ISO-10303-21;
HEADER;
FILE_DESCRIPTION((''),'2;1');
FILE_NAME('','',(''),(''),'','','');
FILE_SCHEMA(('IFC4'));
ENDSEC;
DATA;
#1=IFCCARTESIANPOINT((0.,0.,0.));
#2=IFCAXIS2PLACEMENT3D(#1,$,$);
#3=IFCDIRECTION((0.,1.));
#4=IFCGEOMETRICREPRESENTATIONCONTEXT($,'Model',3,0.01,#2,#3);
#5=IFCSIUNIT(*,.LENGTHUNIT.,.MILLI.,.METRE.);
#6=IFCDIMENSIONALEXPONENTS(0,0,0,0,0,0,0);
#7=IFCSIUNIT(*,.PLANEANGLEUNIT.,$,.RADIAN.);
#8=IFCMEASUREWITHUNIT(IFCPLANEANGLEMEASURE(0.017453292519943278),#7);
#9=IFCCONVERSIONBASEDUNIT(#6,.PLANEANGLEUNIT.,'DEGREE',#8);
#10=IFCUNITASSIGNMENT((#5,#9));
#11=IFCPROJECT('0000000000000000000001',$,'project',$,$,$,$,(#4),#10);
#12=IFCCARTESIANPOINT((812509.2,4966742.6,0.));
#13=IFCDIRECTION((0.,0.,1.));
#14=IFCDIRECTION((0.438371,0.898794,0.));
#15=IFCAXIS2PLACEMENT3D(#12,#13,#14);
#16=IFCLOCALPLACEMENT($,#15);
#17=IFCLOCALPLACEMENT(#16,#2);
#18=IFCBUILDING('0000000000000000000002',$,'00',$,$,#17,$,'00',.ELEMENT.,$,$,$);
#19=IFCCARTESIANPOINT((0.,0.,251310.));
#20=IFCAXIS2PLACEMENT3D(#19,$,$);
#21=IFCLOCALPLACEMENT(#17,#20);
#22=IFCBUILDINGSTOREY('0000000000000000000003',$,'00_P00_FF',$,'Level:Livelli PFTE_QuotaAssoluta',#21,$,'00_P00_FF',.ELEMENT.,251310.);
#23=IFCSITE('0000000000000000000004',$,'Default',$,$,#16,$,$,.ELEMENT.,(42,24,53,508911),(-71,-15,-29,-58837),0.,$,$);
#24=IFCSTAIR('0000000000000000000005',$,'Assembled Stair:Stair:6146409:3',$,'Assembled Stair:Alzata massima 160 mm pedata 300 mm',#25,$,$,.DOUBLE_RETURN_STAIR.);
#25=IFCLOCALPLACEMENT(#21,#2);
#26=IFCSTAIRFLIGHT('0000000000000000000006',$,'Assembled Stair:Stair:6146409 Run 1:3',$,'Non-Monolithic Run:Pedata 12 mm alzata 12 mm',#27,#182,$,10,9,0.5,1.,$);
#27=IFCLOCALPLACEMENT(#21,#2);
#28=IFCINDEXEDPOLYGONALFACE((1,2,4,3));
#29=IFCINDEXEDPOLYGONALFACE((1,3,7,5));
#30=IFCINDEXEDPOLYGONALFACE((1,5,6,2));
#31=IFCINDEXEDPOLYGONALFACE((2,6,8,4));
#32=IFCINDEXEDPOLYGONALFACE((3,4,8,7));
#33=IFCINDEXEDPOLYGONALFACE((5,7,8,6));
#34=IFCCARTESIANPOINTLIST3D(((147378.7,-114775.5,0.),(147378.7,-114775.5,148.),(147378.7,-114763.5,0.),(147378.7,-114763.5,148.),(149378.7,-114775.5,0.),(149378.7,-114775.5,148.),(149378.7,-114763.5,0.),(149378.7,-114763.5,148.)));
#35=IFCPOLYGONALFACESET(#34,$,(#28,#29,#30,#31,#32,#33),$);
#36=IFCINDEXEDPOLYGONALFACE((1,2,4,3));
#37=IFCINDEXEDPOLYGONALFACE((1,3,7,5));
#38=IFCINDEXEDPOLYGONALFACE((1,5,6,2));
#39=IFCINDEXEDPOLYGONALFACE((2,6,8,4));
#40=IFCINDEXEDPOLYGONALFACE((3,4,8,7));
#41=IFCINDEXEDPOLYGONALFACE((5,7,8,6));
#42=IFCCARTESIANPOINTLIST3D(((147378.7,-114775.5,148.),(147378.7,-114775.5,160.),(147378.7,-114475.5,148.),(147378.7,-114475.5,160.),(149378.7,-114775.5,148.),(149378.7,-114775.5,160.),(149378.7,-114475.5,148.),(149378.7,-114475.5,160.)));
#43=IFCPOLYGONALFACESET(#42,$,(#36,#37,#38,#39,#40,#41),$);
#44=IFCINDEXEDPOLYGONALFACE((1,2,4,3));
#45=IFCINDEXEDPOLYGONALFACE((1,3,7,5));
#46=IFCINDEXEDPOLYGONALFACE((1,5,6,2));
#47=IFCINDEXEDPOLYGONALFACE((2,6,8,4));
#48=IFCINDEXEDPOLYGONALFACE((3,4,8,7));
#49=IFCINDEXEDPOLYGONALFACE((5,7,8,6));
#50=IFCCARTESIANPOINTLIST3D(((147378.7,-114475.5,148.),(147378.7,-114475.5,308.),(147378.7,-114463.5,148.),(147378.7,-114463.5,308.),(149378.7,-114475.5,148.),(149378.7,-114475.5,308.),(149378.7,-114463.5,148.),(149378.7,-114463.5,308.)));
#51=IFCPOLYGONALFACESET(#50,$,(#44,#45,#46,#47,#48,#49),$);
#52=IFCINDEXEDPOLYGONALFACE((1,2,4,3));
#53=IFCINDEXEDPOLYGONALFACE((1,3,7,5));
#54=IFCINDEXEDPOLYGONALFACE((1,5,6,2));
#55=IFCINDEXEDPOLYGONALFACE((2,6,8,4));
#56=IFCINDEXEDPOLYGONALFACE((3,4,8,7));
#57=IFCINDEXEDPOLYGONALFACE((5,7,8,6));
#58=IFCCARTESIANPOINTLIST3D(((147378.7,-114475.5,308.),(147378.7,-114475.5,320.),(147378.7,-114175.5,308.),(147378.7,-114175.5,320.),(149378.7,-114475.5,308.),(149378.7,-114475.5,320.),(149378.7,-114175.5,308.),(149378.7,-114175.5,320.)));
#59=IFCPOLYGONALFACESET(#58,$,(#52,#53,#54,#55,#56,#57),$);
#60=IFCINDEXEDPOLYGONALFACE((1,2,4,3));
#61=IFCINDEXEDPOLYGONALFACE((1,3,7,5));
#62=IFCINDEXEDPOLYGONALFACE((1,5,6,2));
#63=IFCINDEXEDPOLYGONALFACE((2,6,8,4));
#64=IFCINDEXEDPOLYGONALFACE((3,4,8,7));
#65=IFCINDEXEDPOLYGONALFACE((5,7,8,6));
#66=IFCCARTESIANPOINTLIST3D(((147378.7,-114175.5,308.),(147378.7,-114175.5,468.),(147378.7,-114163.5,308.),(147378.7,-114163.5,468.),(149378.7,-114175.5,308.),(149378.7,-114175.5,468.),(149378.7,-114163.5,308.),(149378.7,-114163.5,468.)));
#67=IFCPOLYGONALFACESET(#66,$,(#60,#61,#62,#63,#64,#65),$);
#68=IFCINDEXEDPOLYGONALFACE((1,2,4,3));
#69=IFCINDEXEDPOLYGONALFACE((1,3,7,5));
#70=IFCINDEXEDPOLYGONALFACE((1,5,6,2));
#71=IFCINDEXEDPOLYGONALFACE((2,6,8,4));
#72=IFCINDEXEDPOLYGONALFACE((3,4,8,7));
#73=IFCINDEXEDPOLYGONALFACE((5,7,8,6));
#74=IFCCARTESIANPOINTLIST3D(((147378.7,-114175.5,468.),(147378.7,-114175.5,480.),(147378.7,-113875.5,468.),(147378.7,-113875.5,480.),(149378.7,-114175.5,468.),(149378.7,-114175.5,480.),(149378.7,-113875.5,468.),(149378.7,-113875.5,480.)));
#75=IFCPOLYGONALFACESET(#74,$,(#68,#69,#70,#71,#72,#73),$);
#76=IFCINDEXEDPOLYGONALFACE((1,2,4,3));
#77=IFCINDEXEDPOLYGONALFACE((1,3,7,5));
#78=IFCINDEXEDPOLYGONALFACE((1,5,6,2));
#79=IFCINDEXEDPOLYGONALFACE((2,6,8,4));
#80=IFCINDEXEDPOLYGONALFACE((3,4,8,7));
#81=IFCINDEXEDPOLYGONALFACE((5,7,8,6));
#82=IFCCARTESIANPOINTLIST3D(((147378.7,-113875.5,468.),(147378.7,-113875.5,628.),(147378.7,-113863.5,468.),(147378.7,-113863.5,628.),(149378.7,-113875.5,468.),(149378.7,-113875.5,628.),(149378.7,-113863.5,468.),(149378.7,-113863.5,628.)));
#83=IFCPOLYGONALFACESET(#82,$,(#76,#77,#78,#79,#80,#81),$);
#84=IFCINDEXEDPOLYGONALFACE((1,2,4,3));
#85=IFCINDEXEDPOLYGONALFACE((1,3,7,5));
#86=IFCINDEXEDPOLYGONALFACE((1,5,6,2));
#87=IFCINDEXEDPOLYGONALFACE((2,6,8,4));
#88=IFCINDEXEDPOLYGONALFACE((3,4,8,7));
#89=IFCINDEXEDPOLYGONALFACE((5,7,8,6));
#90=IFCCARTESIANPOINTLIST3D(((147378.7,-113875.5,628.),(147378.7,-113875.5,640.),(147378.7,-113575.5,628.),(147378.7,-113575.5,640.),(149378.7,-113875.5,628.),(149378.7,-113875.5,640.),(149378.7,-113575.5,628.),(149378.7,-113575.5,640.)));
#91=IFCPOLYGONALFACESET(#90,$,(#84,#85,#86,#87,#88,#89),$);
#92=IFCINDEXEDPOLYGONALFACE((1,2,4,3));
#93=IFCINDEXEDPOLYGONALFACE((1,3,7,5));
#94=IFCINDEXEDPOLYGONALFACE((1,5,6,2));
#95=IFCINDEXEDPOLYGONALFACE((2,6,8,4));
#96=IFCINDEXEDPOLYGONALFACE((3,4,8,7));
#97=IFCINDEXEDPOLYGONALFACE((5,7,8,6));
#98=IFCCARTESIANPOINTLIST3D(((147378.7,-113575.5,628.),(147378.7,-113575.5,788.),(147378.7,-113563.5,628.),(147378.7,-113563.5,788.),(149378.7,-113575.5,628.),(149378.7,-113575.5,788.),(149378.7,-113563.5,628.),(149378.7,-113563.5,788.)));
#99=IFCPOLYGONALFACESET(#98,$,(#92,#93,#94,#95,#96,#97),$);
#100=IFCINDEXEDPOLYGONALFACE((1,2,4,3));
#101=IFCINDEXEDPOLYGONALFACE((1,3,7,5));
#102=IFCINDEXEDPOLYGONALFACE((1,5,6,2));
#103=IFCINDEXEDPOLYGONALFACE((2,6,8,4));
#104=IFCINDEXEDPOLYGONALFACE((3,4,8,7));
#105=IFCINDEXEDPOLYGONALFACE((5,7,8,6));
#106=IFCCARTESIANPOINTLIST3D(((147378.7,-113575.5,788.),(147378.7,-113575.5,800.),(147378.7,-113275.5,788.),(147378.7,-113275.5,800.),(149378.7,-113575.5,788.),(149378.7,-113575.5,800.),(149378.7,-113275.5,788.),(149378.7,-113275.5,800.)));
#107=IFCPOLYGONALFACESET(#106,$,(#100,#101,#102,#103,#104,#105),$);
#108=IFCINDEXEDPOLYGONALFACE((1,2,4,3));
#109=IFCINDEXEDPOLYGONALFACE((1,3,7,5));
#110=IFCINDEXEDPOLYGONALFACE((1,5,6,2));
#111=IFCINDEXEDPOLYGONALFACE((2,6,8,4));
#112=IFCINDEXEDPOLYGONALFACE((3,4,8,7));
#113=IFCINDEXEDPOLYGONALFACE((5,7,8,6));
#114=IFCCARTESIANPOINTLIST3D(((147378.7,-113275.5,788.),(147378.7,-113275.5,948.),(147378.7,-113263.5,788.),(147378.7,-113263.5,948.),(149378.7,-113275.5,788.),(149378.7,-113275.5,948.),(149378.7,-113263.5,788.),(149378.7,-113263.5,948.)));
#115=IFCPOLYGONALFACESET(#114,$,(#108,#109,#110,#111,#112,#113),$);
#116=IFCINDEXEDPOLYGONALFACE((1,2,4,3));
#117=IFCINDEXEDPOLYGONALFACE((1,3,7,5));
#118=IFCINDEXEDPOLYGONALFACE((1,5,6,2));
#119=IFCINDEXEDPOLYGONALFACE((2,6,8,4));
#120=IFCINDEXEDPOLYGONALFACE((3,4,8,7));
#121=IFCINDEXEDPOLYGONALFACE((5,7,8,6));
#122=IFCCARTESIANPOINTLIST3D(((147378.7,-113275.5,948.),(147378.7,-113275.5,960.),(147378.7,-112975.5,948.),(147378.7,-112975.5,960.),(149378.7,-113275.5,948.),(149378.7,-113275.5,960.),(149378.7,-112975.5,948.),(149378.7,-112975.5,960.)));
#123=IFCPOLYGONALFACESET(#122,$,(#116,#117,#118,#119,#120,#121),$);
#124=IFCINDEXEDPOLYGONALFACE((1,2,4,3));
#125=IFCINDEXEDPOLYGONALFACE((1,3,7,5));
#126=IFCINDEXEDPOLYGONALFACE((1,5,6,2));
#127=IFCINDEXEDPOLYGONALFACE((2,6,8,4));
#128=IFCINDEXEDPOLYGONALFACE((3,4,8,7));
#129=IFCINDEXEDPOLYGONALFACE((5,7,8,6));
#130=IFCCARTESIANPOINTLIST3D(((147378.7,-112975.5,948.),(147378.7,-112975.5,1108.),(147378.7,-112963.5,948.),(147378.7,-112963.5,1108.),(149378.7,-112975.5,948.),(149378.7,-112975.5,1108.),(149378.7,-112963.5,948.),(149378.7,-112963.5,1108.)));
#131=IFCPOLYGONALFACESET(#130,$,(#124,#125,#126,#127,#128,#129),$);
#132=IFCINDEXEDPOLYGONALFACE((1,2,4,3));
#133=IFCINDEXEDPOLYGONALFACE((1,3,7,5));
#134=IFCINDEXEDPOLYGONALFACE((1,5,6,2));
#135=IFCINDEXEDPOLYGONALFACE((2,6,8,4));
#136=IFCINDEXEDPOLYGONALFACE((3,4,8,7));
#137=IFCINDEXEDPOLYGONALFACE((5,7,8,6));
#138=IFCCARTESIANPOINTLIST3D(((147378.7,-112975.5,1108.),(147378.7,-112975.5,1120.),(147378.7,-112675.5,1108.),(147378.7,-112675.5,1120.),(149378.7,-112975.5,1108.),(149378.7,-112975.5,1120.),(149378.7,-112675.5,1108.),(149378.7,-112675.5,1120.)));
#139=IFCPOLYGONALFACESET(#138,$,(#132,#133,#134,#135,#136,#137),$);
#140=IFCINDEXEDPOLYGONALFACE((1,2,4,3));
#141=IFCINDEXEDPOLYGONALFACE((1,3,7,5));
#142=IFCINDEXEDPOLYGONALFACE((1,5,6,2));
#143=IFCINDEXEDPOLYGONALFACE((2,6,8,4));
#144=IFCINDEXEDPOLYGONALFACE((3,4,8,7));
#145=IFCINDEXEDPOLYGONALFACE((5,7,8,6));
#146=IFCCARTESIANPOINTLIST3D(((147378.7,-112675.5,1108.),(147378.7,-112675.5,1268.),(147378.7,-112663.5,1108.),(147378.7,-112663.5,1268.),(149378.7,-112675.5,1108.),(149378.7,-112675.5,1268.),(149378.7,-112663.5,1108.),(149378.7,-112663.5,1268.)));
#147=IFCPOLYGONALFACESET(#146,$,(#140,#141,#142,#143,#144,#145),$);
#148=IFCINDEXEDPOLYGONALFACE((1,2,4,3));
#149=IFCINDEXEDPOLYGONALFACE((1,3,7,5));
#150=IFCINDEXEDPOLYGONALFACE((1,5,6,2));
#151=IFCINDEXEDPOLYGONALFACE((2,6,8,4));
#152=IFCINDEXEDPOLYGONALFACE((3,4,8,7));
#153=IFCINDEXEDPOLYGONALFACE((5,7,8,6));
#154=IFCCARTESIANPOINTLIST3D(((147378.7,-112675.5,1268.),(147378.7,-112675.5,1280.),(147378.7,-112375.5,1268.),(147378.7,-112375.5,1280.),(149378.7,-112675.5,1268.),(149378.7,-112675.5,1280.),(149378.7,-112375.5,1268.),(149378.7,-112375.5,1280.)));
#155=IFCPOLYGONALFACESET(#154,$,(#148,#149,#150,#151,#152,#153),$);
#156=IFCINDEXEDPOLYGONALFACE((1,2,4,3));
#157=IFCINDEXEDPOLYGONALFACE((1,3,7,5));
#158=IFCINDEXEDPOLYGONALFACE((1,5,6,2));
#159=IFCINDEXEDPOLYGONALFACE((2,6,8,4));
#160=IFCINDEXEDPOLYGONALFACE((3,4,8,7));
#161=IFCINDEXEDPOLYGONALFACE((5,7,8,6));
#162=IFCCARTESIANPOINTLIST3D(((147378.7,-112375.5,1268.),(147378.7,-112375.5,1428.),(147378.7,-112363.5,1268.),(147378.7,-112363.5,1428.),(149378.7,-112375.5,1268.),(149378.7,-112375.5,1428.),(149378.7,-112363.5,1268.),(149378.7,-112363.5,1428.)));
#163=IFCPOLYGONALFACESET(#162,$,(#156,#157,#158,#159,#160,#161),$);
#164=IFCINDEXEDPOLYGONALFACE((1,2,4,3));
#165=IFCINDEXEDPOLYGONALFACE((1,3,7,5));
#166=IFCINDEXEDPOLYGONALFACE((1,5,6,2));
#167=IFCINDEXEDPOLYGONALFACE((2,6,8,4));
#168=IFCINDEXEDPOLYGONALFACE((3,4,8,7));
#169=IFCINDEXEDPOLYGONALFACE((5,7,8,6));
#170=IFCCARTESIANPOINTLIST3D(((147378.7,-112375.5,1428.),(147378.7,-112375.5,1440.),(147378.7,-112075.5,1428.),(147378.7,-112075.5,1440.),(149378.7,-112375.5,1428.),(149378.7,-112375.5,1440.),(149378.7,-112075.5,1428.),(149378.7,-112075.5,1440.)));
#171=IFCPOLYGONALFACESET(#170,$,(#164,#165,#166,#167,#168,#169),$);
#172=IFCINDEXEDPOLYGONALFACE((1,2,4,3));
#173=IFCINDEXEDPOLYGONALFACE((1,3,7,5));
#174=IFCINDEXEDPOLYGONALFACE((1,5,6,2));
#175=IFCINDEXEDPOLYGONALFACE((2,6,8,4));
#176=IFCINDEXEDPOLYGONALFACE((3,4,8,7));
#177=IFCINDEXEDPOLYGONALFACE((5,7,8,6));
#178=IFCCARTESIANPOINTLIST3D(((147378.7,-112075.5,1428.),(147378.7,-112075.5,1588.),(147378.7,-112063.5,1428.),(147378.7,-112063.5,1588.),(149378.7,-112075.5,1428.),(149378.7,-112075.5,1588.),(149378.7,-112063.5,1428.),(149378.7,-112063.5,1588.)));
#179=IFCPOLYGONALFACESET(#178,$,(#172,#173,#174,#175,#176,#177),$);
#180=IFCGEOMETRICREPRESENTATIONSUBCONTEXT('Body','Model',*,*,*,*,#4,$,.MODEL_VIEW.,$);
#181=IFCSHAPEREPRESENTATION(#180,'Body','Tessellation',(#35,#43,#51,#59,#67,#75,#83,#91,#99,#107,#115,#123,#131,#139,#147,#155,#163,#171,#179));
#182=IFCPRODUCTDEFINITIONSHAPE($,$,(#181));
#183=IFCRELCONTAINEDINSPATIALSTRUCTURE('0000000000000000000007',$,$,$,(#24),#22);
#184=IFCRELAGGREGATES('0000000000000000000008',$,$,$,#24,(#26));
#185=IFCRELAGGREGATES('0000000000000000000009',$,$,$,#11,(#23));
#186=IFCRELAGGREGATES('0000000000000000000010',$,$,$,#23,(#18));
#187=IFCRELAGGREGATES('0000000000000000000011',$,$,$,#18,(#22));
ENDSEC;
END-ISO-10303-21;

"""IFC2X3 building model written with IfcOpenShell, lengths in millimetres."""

from ifc_helpers import new_model, entity, si_unit, converted_unit, direction, frame, frame_2d, origin, origin_2d_with_axis, place, context, subcontext, project, spatial, rectangle, extrude, element, aggregate, save


model = new_model("IFC2X3")

# Units and contexts
model_context = context("Model", 3, precision=0.01, world=origin(), true_north=direction((0.0, 1.0)))
body_context = subcontext(model_context, "Body", "Model", "MODEL_VIEW")
ifc_project = project(units=[si_unit("LENGTHUNIT", "METRE", prefix="MILLI"), converted_unit("PLANEANGLEUNIT", "DEGREE", entity("IfcPlaneAngleMeasure", 0.017453292519943278), si_unit("PLANEANGLEUNIT", "RADIAN"), dimensions=[0, 0, 0, 0, 0, 0, 0])], contexts=[model_context])

# Site, building, storey
site_placement = place(None, frame((812509.2, 4966742.6, 0.0), z_axis=(0.0, 0.0, 1.0), x_axis=(0.438371, 0.898794, 0.0)))
site = spatial("IfcSite", under=ifc_project, at=site_placement, Name="Default", CompositionType="ELEMENT", RefLatitude=(42, 24, 53, 508911), RefLongitude=(-71, -15, -29, -58837), RefElevation=0.0)
building_placement = place(site_placement, origin())
building = spatial("IfcBuilding", under=site, at=building_placement, Name="00", LongName="00", CompositionType="ELEMENT")
storey_placement = place(building_placement, frame((0.0, 0.0, 251310.0)))
storey = spatial("IfcBuildingStorey", under=building, at=storey_placement, Name="00_P00_FF", ObjectType="Level:Livelli PFTE_QuotaAssoluta", LongName="00_P00_FF", CompositionType="ELEMENT", Elevation=251310.0)

# Stair
stair_1_placement = place(storey_placement, origin())
stair_1 = element("IfcStair", 1, at=stair_1_placement, inside=storey, Name="Assembled Stair:Stair:6146409:3", ObjectType="Assembled Stair:Alzata massima 160 mm pedata 300 mm", ShapeType="DOUBLE_RETURN_STAIR")

# Stair flight
stair_flight_1_placement = place(stair_1_placement, origin())
stair_flight_1 = element("IfcStairFlight", 2, at=stair_flight_1_placement, Name="Assembled Stair:Stair:6146409 Run 1:3", ObjectType="Non-Monolithic Run:Pedata 12 mm alzata 12 mm", NumberOfRiser=10, NumberOfTreads=9, RiserHeight=0.5, TreadLength=1.0, context=body_context, shape_type="SweptSolid", body=[
    extrude(rectangle(XDim=2000.0, YDim=12.0, at=origin_2d_with_axis()), frame((148378.7, -114769.5, 0.0), z_axis=(0.0, 0.0, 1.0), x_axis=(-1.0, 0.0, 0.0)), (0.0, 0.0, 1.0), 148.0),
    extrude(rectangle(XDim=300.0, YDim=2000.0, at=frame_2d((0.0, 0.0), x_axis=(1.0, 0.0))), frame((148378.7, -114625.5, 148.0), z_axis=(0.0, 0.0, 1.0), x_axis=(0.0, -1.0, 0.0)), (0.0, 0.0, 1.0), 12.0),
    extrude(rectangle(XDim=2000.0, YDim=12.0, at=frame_2d((0.0, 0.0), x_axis=(1.0, 0.0))), frame((148378.7, -114469.5, 148.0), z_axis=(0.0, 0.0, 1.0), x_axis=(-1.0, 0.0, 0.0)), (0.0, 0.0, 1.0), 160.0),
    extrude(rectangle(XDim=300.0, YDim=2000.0, at=frame_2d((0.0, 0.0), x_axis=(1.0, 0.0))), frame((148378.7, -114325.5, 308.0), z_axis=(0.0, 0.0, 1.0), x_axis=(0.0, -1.0, 0.0)), (0.0, 0.0, 1.0), 12.0),
    extrude(rectangle(XDim=2000.0, YDim=12.0, at=frame_2d((0.0, 0.0), x_axis=(1.0, 0.0))), frame((148378.7, -114169.5, 308.0), z_axis=(0.0, 0.0, 1.0), x_axis=(-1.0, 0.0, 0.0)), (0.0, 0.0, 1.0), 160.0),
    extrude(rectangle(XDim=300.0, YDim=2000.0, at=frame_2d((0.0, 0.0), x_axis=(1.0, 0.0))), frame((148378.7, -114025.5, 468.0), z_axis=(0.0, 0.0, 1.0), x_axis=(0.0, -1.0, 0.0)), (0.0, 0.0, 1.0), 12.0),
    extrude(rectangle(XDim=2000.0, YDim=12.0, at=frame_2d((0.0, 0.0), x_axis=(1.0, 0.0))), frame((148378.7, -113869.5, 468.0), z_axis=(0.0, 0.0, 1.0), x_axis=(-1.0, 0.0, 0.0)), (0.0, 0.0, 1.0), 160.0),
    extrude(rectangle(XDim=300.0, YDim=2000.0, at=frame_2d((0.0, 0.0), x_axis=(1.0, 0.0))), frame((148378.7, -113725.5, 628.0), z_axis=(0.0, 0.0, 1.0), x_axis=(0.0, -1.0, 0.0)), (0.0, 0.0, 1.0), 12.0),
    extrude(rectangle(XDim=2000.0, YDim=12.0, at=frame_2d((0.0, 0.0), x_axis=(1.0, 0.0))), frame((148378.7, -113569.5, 628.0), z_axis=(0.0, 0.0, 1.0), x_axis=(-1.0, 0.0, 0.0)), (0.0, 0.0, 1.0), 160.0),
    extrude(rectangle(XDim=300.0, YDim=2000.0, at=frame_2d((0.0, 0.0), x_axis=(1.0, 0.0))), frame((148378.7, -113425.5, 788.0), z_axis=(0.0, 0.0, 1.0), x_axis=(0.0, -1.0, 0.0)), (0.0, 0.0, 1.0), 12.0),
    extrude(rectangle(XDim=2000.0, YDim=12.0, at=frame_2d((0.0, 0.0), x_axis=(1.0, 0.0))), frame((148378.7, -113269.5, 788.0), z_axis=(0.0, 0.0, 1.0), x_axis=(-1.0, 0.0, 0.0)), (0.0, 0.0, 1.0), 160.0),
    extrude(rectangle(XDim=300.0, YDim=2000.0, at=frame_2d((0.0, 0.0), x_axis=(1.0, 0.0))), frame((148378.7, -113125.5, 948.0), z_axis=(0.0, 0.0, 1.0), x_axis=(0.0, -1.0, 0.0)), (0.0, 0.0, 1.0), 12.0),
    extrude(rectangle(XDim=2000.0, YDim=12.0, at=frame_2d((0.0, 0.0), x_axis=(1.0, 0.0))), frame((148378.7, -112969.5, 948.0), z_axis=(0.0, 0.0, 1.0), x_axis=(-1.0, 0.0, 0.0)), (0.0, 0.0, 1.0), 160.0),
    extrude(rectangle(XDim=300.0, YDim=2000.0, at=frame_2d((0.0, 0.0), x_axis=(1.0, 0.0))), frame((148378.7, -112825.5, 1108.0), z_axis=(0.0, 0.0, 1.0), x_axis=(0.0, -1.0, 0.0)), (0.0, 0.0, 1.0), 12.0),
    extrude(rectangle(XDim=2000.0, YDim=12.0, at=frame_2d((0.0, 0.0), x_axis=(1.0, 0.0))), frame((148378.7, -112669.5, 1108.0), z_axis=(0.0, 0.0, 1.0), x_axis=(-1.0, 0.0, 0.0)), (0.0, 0.0, 1.0), 160.0),
    extrude(rectangle(XDim=300.0, YDim=2000.0, at=frame_2d((0.0, 0.0), x_axis=(1.0, 0.0))), frame((148378.7, -112525.5, 1268.0), z_axis=(0.0, 0.0, 1.0), x_axis=(0.0, -1.0, 0.0)), (0.0, 0.0, 1.0), 12.0),
    extrude(rectangle(XDim=2000.0, YDim=12.0, at=frame_2d((0.0, 0.0), x_axis=(1.0, 0.0))), frame((148378.7, -112369.5, 1268.0), z_axis=(0.0, 0.0, 1.0), x_axis=(-1.0, 0.0, 0.0)), (0.0, 0.0, 1.0), 160.0),
    extrude(rectangle(XDim=300.0, YDim=2000.0, at=frame_2d((0.0, 0.0), x_axis=(1.0, 0.0))), frame((148378.7, -112225.5, 1428.0), z_axis=(0.0, 0.0, 1.0), x_axis=(0.0, -1.0, 0.0)), (0.0, 0.0, 1.0), 12.0),
    extrude(rectangle(XDim=2000.0, YDim=12.0, at=origin_2d_with_axis()), frame((148378.7, -112069.5, 1428.0), z_axis=(0.0, 0.0, 1.0), x_axis=(-1.0, 0.0, 0.0)), (0.0, 0.0, 1.0), 160.0),
])
aggregate(stair_1, [stair_flight_1])

save(model, "model.ifc")
